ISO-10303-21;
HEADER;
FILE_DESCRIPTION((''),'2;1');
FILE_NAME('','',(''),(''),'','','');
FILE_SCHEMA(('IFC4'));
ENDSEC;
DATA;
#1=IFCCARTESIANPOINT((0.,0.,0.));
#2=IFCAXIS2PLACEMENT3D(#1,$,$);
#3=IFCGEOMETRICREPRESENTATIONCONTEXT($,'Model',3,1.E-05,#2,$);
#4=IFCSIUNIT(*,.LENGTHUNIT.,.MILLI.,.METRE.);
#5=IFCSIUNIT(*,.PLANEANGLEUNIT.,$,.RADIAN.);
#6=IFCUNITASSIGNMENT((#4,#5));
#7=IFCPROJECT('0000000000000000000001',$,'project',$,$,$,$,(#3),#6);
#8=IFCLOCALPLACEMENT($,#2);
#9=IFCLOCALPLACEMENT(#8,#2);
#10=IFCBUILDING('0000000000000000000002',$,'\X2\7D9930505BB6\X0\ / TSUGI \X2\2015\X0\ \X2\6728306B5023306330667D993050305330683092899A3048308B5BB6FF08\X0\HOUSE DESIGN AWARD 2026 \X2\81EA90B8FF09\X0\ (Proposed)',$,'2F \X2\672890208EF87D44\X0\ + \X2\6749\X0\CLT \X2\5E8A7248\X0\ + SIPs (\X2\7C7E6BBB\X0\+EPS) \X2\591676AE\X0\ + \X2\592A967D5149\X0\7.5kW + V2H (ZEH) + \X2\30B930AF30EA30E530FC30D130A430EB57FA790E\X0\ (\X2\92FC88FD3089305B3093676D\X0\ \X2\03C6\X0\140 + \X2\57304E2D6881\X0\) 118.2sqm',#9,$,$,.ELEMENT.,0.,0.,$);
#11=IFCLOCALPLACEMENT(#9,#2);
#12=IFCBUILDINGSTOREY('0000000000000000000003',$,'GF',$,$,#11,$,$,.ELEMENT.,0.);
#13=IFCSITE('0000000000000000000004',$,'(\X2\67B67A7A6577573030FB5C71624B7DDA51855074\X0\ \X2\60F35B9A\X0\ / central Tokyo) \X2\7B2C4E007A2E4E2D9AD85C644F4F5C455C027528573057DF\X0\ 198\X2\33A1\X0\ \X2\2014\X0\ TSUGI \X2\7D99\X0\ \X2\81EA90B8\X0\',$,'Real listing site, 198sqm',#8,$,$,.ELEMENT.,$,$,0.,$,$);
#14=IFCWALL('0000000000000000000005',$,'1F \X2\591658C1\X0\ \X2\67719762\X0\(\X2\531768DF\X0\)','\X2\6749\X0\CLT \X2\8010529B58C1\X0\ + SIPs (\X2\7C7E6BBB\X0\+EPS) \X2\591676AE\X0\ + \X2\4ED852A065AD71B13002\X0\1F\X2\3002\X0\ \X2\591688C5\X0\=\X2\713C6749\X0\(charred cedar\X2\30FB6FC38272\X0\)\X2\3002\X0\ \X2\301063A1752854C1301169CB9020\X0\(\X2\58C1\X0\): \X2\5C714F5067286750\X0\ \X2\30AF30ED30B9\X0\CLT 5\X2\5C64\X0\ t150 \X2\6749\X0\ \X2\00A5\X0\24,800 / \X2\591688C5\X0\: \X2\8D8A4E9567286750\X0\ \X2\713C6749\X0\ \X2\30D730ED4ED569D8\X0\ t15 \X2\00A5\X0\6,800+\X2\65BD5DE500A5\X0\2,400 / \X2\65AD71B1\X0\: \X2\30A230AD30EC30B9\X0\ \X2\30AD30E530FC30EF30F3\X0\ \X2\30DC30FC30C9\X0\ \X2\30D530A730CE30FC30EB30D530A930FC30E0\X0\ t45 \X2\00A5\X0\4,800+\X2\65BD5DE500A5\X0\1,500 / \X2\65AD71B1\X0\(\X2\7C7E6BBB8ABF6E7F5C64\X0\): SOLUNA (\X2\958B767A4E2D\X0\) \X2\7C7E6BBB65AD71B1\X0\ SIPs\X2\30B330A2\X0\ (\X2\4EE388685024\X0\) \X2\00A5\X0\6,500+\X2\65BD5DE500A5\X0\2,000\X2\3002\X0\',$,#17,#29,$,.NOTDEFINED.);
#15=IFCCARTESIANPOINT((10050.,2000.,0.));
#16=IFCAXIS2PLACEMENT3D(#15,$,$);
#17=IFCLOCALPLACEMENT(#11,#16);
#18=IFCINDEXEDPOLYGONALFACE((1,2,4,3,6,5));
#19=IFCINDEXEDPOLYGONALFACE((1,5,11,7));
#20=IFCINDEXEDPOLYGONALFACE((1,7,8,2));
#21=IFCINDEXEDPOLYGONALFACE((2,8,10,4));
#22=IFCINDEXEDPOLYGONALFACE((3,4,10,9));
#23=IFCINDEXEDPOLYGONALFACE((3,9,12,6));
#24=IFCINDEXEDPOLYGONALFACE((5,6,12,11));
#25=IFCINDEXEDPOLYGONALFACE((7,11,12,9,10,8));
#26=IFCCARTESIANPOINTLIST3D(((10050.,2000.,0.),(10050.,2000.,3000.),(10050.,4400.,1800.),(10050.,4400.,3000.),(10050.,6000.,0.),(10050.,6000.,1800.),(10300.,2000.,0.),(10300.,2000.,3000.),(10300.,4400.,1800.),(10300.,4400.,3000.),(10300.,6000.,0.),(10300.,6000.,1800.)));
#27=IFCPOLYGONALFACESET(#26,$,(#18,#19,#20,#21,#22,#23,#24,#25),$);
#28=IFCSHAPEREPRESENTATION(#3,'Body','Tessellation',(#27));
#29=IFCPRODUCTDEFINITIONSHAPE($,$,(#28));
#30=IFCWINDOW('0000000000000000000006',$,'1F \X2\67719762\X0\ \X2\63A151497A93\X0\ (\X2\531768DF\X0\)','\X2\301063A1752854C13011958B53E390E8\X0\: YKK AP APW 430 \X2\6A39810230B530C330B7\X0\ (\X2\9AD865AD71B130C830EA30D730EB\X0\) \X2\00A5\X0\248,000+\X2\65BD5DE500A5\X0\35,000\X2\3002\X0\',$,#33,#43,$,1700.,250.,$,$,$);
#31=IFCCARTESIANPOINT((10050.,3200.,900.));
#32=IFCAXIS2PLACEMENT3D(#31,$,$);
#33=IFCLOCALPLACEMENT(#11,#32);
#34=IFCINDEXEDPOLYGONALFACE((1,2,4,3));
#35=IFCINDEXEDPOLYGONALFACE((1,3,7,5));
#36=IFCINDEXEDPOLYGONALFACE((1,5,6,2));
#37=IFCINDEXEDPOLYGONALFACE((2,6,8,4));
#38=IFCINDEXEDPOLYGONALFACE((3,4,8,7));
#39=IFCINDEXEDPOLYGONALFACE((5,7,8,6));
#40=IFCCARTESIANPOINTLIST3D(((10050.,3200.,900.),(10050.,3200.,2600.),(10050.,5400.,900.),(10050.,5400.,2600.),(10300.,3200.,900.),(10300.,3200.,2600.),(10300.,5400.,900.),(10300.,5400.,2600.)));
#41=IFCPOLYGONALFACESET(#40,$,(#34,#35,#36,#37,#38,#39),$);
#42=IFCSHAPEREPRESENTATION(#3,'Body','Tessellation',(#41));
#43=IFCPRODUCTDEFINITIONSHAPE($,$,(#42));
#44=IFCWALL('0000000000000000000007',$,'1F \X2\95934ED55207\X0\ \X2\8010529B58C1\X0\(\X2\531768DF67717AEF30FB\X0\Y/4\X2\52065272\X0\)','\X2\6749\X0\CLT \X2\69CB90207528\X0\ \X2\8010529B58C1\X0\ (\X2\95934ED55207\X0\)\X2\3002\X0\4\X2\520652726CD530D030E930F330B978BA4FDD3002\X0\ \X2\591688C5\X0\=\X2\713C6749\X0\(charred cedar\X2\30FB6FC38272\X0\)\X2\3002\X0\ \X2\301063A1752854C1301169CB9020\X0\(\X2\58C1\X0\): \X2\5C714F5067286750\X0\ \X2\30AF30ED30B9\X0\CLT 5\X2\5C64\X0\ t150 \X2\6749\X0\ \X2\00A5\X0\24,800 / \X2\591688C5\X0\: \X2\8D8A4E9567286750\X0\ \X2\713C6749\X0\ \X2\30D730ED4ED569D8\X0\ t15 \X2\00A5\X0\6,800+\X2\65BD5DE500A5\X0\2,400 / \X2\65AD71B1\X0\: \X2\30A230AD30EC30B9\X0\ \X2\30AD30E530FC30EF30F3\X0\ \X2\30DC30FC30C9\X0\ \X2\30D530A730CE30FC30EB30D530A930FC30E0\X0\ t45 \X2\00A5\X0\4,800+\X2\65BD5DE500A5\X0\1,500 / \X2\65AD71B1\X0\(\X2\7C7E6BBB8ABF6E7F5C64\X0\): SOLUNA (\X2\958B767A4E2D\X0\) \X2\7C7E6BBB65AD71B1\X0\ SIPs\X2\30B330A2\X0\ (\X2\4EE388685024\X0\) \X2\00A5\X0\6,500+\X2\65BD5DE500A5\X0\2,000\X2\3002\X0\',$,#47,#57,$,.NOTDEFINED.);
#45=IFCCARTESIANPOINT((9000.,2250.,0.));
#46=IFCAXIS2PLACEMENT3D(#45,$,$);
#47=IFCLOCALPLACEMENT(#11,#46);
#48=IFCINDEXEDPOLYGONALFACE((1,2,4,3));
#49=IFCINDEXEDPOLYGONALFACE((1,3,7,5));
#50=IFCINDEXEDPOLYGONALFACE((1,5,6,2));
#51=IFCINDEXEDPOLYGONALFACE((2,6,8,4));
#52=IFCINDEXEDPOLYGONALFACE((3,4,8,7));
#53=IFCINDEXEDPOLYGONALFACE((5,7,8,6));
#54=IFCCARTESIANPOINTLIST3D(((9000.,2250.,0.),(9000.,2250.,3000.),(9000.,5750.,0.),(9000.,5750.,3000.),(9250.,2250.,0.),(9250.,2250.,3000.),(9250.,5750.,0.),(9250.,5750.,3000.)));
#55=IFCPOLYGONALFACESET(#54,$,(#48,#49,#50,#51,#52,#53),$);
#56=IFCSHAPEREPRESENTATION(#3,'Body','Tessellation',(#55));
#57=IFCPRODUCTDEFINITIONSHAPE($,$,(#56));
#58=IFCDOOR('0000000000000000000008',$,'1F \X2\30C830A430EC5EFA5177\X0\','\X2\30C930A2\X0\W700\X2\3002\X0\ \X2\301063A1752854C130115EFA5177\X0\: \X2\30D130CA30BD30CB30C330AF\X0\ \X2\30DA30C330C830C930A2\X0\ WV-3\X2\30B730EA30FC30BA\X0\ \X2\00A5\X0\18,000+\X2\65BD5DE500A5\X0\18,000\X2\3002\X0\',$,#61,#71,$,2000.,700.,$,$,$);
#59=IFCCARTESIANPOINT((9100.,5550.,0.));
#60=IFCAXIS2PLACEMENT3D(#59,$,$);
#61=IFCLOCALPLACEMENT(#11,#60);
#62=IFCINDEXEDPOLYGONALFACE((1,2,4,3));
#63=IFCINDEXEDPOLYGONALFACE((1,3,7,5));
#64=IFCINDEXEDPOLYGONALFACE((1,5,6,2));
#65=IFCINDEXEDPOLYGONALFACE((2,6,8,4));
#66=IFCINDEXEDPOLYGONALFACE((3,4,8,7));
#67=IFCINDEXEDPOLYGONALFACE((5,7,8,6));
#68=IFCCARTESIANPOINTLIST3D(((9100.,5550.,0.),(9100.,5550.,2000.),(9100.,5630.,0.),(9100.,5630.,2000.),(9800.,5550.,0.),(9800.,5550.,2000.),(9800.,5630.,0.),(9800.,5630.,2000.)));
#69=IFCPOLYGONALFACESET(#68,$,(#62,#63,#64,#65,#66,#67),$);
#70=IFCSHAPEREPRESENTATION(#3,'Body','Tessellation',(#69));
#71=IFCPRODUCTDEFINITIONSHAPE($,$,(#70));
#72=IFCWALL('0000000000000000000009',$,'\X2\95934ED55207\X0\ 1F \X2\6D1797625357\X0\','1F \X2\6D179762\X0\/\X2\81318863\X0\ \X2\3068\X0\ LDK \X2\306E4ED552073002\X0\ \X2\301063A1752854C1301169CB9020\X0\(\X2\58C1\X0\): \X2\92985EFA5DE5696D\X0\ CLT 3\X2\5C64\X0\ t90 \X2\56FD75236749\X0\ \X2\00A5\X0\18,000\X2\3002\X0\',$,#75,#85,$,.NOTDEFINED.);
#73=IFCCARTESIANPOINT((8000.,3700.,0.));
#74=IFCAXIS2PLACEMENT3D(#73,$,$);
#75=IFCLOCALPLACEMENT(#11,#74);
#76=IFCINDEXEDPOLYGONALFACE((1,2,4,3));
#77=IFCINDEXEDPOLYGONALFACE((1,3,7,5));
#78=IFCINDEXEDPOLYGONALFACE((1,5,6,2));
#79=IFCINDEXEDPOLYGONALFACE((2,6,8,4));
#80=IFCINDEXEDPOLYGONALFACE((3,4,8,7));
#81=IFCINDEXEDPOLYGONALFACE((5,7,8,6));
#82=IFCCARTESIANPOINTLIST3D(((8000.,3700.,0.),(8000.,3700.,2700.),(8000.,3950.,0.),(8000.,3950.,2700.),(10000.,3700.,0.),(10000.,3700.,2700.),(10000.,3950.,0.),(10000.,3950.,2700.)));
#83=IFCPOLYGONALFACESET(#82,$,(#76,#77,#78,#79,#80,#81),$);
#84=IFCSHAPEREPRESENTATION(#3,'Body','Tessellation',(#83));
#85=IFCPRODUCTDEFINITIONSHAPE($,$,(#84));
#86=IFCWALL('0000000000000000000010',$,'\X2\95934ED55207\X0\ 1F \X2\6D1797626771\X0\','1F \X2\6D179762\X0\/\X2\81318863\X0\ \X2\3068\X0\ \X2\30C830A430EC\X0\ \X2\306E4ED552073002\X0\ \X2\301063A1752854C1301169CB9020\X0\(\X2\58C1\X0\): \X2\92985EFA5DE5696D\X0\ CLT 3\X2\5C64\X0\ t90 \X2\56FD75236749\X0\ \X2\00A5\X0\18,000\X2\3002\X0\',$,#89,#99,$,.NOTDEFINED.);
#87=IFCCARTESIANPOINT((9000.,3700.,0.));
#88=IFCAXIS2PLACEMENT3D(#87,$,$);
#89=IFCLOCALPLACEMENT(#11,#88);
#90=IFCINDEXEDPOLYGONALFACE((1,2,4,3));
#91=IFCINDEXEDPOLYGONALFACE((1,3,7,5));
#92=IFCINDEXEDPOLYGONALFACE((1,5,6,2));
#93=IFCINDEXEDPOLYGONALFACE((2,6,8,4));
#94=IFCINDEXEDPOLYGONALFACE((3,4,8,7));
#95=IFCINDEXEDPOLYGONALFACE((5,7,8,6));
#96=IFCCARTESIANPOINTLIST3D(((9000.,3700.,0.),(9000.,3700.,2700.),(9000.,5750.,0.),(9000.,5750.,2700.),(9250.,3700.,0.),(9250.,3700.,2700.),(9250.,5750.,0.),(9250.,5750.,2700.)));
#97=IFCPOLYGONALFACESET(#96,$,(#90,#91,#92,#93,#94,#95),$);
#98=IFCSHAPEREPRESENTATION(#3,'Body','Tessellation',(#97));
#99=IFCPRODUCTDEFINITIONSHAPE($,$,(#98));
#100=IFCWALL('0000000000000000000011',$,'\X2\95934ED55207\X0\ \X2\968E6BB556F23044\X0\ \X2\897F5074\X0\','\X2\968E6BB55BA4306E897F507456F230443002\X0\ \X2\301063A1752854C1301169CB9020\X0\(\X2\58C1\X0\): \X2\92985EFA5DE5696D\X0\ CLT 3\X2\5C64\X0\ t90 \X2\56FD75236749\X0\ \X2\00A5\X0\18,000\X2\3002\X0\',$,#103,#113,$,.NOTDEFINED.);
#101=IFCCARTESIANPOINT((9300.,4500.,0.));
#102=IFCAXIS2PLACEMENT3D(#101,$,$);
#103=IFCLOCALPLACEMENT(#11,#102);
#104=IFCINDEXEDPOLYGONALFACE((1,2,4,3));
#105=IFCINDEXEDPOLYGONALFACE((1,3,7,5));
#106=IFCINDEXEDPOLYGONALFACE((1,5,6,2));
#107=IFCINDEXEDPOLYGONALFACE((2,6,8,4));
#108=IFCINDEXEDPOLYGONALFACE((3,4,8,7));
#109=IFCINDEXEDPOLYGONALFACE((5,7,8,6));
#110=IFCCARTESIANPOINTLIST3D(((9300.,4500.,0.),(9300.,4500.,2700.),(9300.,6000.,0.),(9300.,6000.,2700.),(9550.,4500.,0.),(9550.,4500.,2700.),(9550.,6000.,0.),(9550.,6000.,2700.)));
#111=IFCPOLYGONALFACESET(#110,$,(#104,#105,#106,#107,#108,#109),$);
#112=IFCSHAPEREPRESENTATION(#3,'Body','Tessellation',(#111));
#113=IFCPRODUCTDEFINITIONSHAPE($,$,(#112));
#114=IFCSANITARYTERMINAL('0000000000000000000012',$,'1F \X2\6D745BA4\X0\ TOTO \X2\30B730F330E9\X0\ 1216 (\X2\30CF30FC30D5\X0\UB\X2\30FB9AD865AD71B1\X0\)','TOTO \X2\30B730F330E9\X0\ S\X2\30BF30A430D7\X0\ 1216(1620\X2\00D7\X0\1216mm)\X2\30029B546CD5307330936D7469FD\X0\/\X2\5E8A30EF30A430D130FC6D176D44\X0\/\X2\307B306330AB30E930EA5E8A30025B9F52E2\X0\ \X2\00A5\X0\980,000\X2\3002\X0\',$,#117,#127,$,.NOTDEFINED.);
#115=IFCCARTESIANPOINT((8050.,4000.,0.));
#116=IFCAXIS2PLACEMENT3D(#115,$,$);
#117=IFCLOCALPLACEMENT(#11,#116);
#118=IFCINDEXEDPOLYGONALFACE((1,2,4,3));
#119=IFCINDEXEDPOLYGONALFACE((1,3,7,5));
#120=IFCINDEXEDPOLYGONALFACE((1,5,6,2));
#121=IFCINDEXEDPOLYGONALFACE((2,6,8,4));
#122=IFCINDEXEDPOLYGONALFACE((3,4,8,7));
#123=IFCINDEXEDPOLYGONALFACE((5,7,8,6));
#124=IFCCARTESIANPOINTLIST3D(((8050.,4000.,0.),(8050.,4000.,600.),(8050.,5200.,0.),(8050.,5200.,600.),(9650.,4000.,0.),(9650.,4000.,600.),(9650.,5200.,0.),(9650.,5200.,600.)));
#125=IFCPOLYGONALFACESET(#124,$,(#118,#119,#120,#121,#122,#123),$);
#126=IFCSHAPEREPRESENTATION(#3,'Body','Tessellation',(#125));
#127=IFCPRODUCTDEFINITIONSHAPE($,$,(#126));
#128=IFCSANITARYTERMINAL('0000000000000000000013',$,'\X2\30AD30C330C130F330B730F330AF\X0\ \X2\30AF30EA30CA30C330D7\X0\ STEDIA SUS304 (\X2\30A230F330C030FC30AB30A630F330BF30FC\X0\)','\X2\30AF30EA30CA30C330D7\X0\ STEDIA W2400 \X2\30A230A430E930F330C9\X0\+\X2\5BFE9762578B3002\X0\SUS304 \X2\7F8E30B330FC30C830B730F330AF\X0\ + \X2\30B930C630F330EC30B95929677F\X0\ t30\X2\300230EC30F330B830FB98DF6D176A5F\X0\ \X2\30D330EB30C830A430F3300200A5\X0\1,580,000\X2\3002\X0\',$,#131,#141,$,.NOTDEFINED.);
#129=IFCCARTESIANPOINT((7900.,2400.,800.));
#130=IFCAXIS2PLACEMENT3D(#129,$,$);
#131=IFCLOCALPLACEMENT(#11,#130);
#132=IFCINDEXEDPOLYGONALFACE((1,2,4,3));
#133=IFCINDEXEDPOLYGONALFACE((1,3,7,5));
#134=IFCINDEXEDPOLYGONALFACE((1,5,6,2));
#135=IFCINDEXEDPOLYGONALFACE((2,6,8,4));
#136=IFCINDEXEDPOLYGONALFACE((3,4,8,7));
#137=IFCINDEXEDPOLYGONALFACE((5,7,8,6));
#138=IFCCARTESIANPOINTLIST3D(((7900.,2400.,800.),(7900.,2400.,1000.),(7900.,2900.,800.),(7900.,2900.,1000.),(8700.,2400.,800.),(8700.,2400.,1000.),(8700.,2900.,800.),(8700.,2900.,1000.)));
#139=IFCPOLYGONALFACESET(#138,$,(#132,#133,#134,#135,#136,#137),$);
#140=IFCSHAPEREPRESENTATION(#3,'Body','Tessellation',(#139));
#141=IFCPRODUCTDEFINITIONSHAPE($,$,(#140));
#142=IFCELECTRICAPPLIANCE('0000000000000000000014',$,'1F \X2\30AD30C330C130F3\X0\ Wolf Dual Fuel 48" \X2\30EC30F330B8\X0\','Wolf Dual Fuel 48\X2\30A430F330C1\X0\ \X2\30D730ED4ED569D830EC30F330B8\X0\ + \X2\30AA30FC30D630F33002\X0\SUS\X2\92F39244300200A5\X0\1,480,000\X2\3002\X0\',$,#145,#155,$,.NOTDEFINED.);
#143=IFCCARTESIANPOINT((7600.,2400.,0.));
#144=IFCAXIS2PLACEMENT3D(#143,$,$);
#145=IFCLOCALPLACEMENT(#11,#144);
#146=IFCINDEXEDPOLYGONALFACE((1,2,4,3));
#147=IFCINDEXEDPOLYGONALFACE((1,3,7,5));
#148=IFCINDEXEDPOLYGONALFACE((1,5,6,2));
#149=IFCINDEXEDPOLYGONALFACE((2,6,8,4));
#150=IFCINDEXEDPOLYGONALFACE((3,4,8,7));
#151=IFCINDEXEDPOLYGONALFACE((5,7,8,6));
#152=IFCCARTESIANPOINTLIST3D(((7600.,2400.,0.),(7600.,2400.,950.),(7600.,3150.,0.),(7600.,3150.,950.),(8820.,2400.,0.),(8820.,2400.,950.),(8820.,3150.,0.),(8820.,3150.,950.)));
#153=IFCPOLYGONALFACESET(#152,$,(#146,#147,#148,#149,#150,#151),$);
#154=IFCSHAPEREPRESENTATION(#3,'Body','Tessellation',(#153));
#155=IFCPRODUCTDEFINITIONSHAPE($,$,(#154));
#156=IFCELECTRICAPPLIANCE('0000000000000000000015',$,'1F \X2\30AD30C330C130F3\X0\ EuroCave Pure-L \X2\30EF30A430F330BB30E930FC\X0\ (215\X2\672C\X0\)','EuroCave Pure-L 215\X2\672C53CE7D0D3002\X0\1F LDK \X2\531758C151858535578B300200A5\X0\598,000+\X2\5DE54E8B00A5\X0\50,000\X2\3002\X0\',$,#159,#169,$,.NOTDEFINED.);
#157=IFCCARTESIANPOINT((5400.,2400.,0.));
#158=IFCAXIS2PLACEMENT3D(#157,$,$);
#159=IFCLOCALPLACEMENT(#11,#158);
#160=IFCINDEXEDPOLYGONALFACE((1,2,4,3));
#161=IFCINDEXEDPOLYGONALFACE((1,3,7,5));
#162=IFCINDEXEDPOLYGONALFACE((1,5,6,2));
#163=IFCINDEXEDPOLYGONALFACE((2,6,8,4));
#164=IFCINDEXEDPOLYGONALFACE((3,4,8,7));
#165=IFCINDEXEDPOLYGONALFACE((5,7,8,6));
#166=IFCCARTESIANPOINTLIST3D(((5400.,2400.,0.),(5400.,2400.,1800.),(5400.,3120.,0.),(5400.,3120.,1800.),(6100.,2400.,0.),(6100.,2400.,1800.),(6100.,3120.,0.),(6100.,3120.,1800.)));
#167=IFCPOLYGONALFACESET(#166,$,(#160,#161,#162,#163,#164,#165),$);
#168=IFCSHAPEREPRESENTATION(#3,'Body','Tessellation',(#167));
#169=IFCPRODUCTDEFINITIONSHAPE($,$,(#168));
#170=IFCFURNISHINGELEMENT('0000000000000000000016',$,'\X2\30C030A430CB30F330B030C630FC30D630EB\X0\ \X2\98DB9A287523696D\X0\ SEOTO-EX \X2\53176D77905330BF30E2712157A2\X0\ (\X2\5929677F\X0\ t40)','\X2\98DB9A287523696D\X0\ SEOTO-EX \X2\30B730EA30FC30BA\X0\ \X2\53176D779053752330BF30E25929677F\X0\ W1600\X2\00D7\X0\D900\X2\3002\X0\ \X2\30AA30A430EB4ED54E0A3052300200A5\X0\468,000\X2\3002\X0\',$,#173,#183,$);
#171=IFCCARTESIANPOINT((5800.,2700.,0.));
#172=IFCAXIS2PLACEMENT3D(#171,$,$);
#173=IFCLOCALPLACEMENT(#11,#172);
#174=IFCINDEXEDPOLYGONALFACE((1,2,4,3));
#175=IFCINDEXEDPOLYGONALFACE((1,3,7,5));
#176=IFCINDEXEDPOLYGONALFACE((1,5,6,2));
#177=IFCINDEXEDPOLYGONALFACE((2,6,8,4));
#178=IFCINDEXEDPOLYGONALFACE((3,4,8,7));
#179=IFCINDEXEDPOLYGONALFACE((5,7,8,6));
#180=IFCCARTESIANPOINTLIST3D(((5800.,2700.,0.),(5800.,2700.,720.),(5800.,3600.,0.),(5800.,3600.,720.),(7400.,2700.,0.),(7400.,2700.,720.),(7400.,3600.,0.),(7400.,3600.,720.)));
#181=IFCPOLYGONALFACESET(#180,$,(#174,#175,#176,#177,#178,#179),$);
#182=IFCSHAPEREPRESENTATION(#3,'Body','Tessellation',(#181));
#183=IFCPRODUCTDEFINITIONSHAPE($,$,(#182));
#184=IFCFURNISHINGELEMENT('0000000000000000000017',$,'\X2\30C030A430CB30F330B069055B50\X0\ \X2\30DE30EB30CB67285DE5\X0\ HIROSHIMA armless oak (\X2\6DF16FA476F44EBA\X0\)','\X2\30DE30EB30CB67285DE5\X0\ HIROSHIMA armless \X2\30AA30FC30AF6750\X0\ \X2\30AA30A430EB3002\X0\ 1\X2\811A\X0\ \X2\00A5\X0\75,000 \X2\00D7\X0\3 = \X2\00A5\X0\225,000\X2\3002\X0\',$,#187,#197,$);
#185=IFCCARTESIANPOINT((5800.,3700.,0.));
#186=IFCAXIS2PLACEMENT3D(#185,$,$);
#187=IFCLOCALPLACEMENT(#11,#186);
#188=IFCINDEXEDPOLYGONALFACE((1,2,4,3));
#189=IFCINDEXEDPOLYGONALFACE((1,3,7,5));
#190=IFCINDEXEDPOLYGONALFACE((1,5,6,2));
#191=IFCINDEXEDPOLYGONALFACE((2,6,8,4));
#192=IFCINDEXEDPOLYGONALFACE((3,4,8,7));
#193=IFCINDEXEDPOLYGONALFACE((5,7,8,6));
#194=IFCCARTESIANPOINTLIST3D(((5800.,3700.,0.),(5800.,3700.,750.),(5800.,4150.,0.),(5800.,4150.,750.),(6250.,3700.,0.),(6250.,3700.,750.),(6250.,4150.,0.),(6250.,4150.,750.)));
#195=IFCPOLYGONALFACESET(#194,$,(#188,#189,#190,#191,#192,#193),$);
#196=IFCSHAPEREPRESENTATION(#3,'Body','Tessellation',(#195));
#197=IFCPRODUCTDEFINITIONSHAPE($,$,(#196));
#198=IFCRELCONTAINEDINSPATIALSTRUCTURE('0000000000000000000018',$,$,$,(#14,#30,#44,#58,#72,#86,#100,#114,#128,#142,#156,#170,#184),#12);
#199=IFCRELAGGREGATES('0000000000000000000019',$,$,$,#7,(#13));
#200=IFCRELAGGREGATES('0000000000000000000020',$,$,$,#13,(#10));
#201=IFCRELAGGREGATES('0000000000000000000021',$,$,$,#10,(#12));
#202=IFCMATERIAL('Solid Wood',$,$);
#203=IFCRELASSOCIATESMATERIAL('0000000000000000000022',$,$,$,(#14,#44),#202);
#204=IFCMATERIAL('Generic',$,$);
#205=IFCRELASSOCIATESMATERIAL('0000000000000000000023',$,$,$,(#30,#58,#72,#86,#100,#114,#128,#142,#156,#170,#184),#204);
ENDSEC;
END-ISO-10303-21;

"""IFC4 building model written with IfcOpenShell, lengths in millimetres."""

from ifc_helpers import new_model, si_unit, frame, frame_2d, origin, place, context, project, spatial, rectangle, extrude, material, element, fill, save


model = new_model("IFC4")

# Units and contexts
model_context = context("Model", 3, precision=1e-05, world=origin())
ifc_project = project(units=[si_unit("LENGTHUNIT", "METRE", prefix="MILLI"), si_unit("PLANEANGLEUNIT", "RADIAN")], contexts=[model_context])

# Site, building, storey
site_placement = place(None, origin())
site = spatial("IfcSite", under=ifc_project, at=site_placement, Name="(架空敷地・山手線内側 想定 / central Tokyo) 第一種中高層住居専用地域 198㎡ — TSUGI 継 自邸", ObjectType="Real listing site, 198sqm", CompositionType="ELEMENT", RefElevation=0.0)
building_placement = place(site_placement, origin())
building = spatial("IfcBuilding", under=site, at=building_placement, Name="継ぐ家 / TSUGI ― 木に倣って継ぐことを覚える家（HOUSE DESIGN AWARD 2026 自邸） (Proposed)", ObjectType="2F 木造軸組 + 杉CLT 床版 + SIPs (籾殻+EPS) 外皮 + 太陽光7.5kW + V2H (ZEH) + スクリューパイル基礎 (鋼製らせん杭 φ140 + 地中梁) 118.2sqm", CompositionType="ELEMENT", ElevationOfRefHeight=0.0, ElevationOfTerrain=0.0)
storey_placement = place(building_placement, origin())
storey = spatial("IfcBuildingStorey", under=building, at=storey_placement, Name="GF", CompositionType="ELEMENT", Elevation=0.0)

# Shared definitions
ifc_material_1 = material(Name="Generic")

# Wall, opening, window
ifc_material_2 = material(Name="Solid Wood")
wall_1_placement = place(storey_placement, frame((10050.0, 2000.0, 0.0)))
wall_1 = element("IfcWall", 1, at=wall_1_placement, inside=storey, material=ifc_material_2, Name="1F 外壁 東面(北棟)", Description="杉CLT 耐力壁 + SIPs (籾殻+EPS) 外皮 + 付加断熱。1F。 外装=焼杉(charred cedar・濃色)。 【採用品】構造(壁): 山佐木材 クロスCLT 5層 t150 杉 ¥24,800 / 外装: 越井木材 焼杉 プロ仕様 t15 ¥6,800+施工¥2,400 / 断熱: アキレス キューワン ボード フェノールフォーム t45 ¥4,800+施工¥1,500 / 断熱(籾殻調湿層): SOLUNA (開発中) 籾殻断熱 SIPsコア (代表値) ¥6,500+施工¥2,000。", PredefinedType="NOTDEFINED", context=model_context, shape_type="SweptSolid", body=[
    extrude(rectangle(XDim=250.0, YDim=4000.0, at=frame_2d((125.0, 2000.0))), frame((10050.0, 2000.0, 0.0)), (0.0, 0.0, 1.0), 3000.0),
])
opening_1_placement = place(storey_placement, frame((10050.0, 3200.0, 900.0)))
opening_1 = element("IfcOpeningElement", 2, at=opening_1_placement, cuts=wall_1, PredefinedType="NOTDEFINED", context=model_context, shape_type="SweptSolid", body=[
    extrude(rectangle(XDim=250.0, YDim=2200.0, at=frame_2d((125.0, 1100.0))), frame((10050.0, 3200.0, 900.0)), (0.0, 0.0, 1.0), 1700.0),
])
window_placement = place(storey_placement, frame((10050.0, 3200.0, 900.0)))
window = element("IfcWindow", 3, at=window_placement, inside=storey, material=ifc_material_1, Name="1F 東面 採光窓 (北棟)", Description="【採用品】開口部: YKK AP APW 430 樹脂サッシ (高断熱トリプル) ¥248,000+施工¥35,000。", OverallHeight=1700.0, OverallWidth=250.0, context=model_context, shape_type="SweptSolid", body=[
    extrude(rectangle(XDim=250.0, YDim=2200.0, at=frame_2d((125.0, 1100.0))), frame((10050.0, 3200.0, 900.0)), (0.0, 0.0, 1.0), 1700.0),
])
fill(opening_1, window)

# Wall, opening, door
wall_2_placement = place(storey_placement, frame((9000.0, 2250.0, 0.0)))
wall_2 = element("IfcWall", 4, at=wall_2_placement, inside=storey, material=ifc_material_2, Name="1F 間仕切 耐力壁(北棟東端・Y/4分割)", Description="杉CLT 構造用 耐力壁 (間仕切)。4分割法バランス確保。 外装=焼杉(charred cedar・濃色)。 【採用品】構造(壁): 山佐木材 クロスCLT 5層 t150 杉 ¥24,800 / 外装: 越井木材 焼杉 プロ仕様 t15 ¥6,800+施工¥2,400 / 断熱: アキレス キューワン ボード フェノールフォーム t45 ¥4,800+施工¥1,500 / 断熱(籾殻調湿層): SOLUNA (開発中) 籾殻断熱 SIPsコア (代表値) ¥6,500+施工¥2,000。", PredefinedType="NOTDEFINED", context=model_context, shape_type="SweptSolid", body=[
    extrude(rectangle(XDim=250.0, YDim=3500.0, at=frame_2d((125.0, 1750.0))), frame((9000.0, 2250.0, 0.0)), (0.0, 0.0, 1.0), 3000.0),
])
opening_2_placement = place(storey_placement, frame((9100.0, 5550.0, 0.0)))
opening_2 = element("IfcOpeningElement", 5, at=opening_2_placement, cuts=wall_2, PredefinedType="NOTDEFINED", context=model_context, shape_type="SweptSolid", body=[
    extrude(rectangle(XDim=700.0, YDim=80.0, at=frame_2d((350.0, 40.0))), frame((9100.0, 5550.0, 0.0)), (0.0, 0.0, 1.0), 2000.0),
])
door_placement = place(storey_placement, frame((9100.0, 5550.0, 0.0)))
door = element("IfcDoor", 6, at=door_placement, inside=storey, material=ifc_material_1, Name="1F トイレ建具", Description="ドアW700。 【採用品】建具: パナソニック ペットドア WV-3シリーズ ¥18,000+施工¥18,000。", OverallHeight=2000.0, OverallWidth=700.0, context=model_context, shape_type="SweptSolid", body=[
    extrude(rectangle(XDim=700.0, YDim=80.0, at=frame_2d((350.0, 40.0))), frame((9100.0, 5550.0, 0.0)), (0.0, 0.0, 1.0), 2000.0),
])
fill(opening_2, door)

# Walls
wall_3_placement = place(storey_placement, frame((8000.0, 3700.0, 0.0)))
element("IfcWall", 7, at=wall_3_placement, inside=storey, material=ifc_material_1, Name="間仕切 1F 洗面南", Description="1F 洗面/脱衣 と LDK の仕切。 【採用品】構造(壁): 銘建工業 CLT 3層 t90 国産杉 ¥18,000。", PredefinedType="NOTDEFINED", context=model_context, shape_type="SweptSolid", body=[
    extrude(rectangle(XDim=2000.0, YDim=250.0, at=frame_2d((1000.0, 125.0))), frame((8000.0, 3700.0, 0.0)), (0.0, 0.0, 1.0), 2700.0),
])
wall_4_placement = place(storey_placement, frame((9000.0, 3700.0, 0.0)))
element("IfcWall", 8, at=wall_4_placement, inside=storey, material=ifc_material_1, Name="間仕切 1F 洗面東", Description="1F 洗面/脱衣 と トイレ の仕切。 【採用品】構造(壁): 銘建工業 CLT 3層 t90 国産杉 ¥18,000。", PredefinedType="NOTDEFINED", context=model_context, shape_type="SweptSolid", body=[
    extrude(rectangle(XDim=250.0, YDim=2050.0, at=frame_2d((125.0, 1025.0))), frame((9000.0, 3700.0, 0.0)), (0.0, 0.0, 1.0), 2700.0),
])
wall_5_placement = place(storey_placement, frame((9300.0, 4500.0, 0.0)))
element("IfcWall", 9, at=wall_5_placement, inside=storey, material=ifc_material_1, Name="間仕切 階段囲い 西側", Description="階段室の西側囲い。 【採用品】構造(壁): 銘建工業 CLT 3層 t90 国産杉 ¥18,000。", PredefinedType="NOTDEFINED", context=model_context, shape_type="SweptSolid", body=[
    extrude(rectangle(XDim=250.0, YDim=1500.0, at=frame_2d((125.0, 750.0))), frame((9300.0, 4500.0, 0.0)), (0.0, 0.0, 1.0), 2700.0),
])

# Sanitary terminals
sanitary_terminal_1_placement = place(storey_placement, frame((8050.0, 4000.0, 0.0)))
element("IfcSanitaryTerminal", 10, at=sanitary_terminal_1_placement, inside=storey, material=ifc_material_1, Name="1F 浴室 TOTO シンラ 1216 (ハーフUB・高断熱)", Description="TOTO シンラ Sタイプ 1216(1620×1216mm)。魔法びん浴槽/床ワイパー洗浄/ほっカラリ床。実勢 ¥980,000。", PredefinedType="NOTDEFINED", context=model_context, shape_type="SweptSolid", body=[
    extrude(rectangle(XDim=1600.0, YDim=1200.0, at=frame_2d((800.0, 600.0))), frame((8050.0, 4000.0, 0.0)), (0.0, 0.0, 1.0), 600.0),
])
sanitary_terminal_2_placement = place(storey_placement, frame((7900.0, 2400.0, 800.0)))
element("IfcSanitaryTerminal", 11, at=sanitary_terminal_2_placement, inside=storey, material=ifc_material_1, Name="キッチンシンク クリナップ STEDIA SUS304 (アンダーカウンター)", Description="クリナップ STEDIA W2400 アイランド+対面型。SUS304 美コートシンク + ステンレス天板 t30。レンジ・食洗機 ビルトイン。¥1,580,000。", PredefinedType="NOTDEFINED", context=model_context, shape_type="SweptSolid", body=[
    extrude(rectangle(XDim=800.0, YDim=500.0, at=frame_2d((400.0, 250.0))), frame((7900.0, 2400.0, 800.0)), (0.0, 0.0, 1.0), 200.0),
])

# Electric appliances
electric_appliance_1_placement = place(storey_placement, frame((7600.0, 2400.0, 0.0)))
element("IfcElectricAppliance", 12, at=electric_appliance_1_placement, inside=storey, material=ifc_material_1, Name="1F キッチン Wolf Dual Fuel 48\" レンジ", Description="Wolf Dual Fuel 48インチ プロ仕様レンジ + オーブン。SUS鋳鉄。¥1,480,000。", PredefinedType="NOTDEFINED", context=model_context, shape_type="SweptSolid", body=[
    extrude(rectangle(XDim=1220.0, YDim=750.0, at=frame_2d((610.0, 375.0))), frame((7600.0, 2400.0, 0.0)), (0.0, 0.0, 1.0), 950.0),
])
electric_appliance_2_placement = place(storey_placement, frame((5400.0, 2400.0, 0.0)))
element("IfcElectricAppliance", 13, at=electric_appliance_2_placement, inside=storey, material=ifc_material_1, Name="1F キッチン EuroCave Pure-L ワインセラー (215本)", Description="EuroCave Pure-L 215本収納。1F LDK 北壁内蔵型。¥598,000+工事¥50,000。", PredefinedType="NOTDEFINED", context=model_context, shape_type="SweptSolid", body=[
    extrude(rectangle(XDim=700.0, YDim=720.0, at=frame_2d((350.0, 360.0))), frame((5400.0, 2400.0, 0.0)), (0.0, 0.0, 1.0), 1800.0),
])

# Furnishing elements
furnishing_1_placement = place(storey_placement, frame((5800.0, 2700.0, 0.0)))
element("IfcFurnishingElement", 14, at=furnishing_1_placement, inside=storey, material=ifc_material_1, Name="ダイニングテーブル 飛騨産業 SEOTO-EX 北海道タモ無垢 (天板 t40)", Description="飛騨産業 SEOTO-EX シリーズ 北海道産タモ天板 W1600×D900。 オイル仕上げ。¥468,000。", context=model_context, shape_type="SweptSolid", body=[
    extrude(rectangle(XDim=1600.0, YDim=900.0, at=frame_2d((800.0, 450.0))), frame((5800.0, 2700.0, 0.0)), (0.0, 0.0, 1.0), 720.0),
])
furnishing_2_placement = place(storey_placement, frame((5800.0, 3700.0, 0.0)))
element("IfcFurnishingElement", 15, at=furnishing_2_placement, inside=storey, material=ifc_material_1, Name="ダイニング椅子 マルニ木工 HIROSHIMA armless oak (深澤直人)", Description="マルニ木工 HIROSHIMA armless オーク材 オイル。 1脚 ¥75,000 ×3 = ¥225,000。", context=model_context, shape_type="SweptSolid", body=[
    extrude(rectangle(XDim=450.0, YDim=450.0, at=frame_2d((225.0, 225.0))), frame((5800.0, 3700.0, 0.0)), (0.0, 0.0, 1.0), 750.0),
])

save(model, "model.ifc")
